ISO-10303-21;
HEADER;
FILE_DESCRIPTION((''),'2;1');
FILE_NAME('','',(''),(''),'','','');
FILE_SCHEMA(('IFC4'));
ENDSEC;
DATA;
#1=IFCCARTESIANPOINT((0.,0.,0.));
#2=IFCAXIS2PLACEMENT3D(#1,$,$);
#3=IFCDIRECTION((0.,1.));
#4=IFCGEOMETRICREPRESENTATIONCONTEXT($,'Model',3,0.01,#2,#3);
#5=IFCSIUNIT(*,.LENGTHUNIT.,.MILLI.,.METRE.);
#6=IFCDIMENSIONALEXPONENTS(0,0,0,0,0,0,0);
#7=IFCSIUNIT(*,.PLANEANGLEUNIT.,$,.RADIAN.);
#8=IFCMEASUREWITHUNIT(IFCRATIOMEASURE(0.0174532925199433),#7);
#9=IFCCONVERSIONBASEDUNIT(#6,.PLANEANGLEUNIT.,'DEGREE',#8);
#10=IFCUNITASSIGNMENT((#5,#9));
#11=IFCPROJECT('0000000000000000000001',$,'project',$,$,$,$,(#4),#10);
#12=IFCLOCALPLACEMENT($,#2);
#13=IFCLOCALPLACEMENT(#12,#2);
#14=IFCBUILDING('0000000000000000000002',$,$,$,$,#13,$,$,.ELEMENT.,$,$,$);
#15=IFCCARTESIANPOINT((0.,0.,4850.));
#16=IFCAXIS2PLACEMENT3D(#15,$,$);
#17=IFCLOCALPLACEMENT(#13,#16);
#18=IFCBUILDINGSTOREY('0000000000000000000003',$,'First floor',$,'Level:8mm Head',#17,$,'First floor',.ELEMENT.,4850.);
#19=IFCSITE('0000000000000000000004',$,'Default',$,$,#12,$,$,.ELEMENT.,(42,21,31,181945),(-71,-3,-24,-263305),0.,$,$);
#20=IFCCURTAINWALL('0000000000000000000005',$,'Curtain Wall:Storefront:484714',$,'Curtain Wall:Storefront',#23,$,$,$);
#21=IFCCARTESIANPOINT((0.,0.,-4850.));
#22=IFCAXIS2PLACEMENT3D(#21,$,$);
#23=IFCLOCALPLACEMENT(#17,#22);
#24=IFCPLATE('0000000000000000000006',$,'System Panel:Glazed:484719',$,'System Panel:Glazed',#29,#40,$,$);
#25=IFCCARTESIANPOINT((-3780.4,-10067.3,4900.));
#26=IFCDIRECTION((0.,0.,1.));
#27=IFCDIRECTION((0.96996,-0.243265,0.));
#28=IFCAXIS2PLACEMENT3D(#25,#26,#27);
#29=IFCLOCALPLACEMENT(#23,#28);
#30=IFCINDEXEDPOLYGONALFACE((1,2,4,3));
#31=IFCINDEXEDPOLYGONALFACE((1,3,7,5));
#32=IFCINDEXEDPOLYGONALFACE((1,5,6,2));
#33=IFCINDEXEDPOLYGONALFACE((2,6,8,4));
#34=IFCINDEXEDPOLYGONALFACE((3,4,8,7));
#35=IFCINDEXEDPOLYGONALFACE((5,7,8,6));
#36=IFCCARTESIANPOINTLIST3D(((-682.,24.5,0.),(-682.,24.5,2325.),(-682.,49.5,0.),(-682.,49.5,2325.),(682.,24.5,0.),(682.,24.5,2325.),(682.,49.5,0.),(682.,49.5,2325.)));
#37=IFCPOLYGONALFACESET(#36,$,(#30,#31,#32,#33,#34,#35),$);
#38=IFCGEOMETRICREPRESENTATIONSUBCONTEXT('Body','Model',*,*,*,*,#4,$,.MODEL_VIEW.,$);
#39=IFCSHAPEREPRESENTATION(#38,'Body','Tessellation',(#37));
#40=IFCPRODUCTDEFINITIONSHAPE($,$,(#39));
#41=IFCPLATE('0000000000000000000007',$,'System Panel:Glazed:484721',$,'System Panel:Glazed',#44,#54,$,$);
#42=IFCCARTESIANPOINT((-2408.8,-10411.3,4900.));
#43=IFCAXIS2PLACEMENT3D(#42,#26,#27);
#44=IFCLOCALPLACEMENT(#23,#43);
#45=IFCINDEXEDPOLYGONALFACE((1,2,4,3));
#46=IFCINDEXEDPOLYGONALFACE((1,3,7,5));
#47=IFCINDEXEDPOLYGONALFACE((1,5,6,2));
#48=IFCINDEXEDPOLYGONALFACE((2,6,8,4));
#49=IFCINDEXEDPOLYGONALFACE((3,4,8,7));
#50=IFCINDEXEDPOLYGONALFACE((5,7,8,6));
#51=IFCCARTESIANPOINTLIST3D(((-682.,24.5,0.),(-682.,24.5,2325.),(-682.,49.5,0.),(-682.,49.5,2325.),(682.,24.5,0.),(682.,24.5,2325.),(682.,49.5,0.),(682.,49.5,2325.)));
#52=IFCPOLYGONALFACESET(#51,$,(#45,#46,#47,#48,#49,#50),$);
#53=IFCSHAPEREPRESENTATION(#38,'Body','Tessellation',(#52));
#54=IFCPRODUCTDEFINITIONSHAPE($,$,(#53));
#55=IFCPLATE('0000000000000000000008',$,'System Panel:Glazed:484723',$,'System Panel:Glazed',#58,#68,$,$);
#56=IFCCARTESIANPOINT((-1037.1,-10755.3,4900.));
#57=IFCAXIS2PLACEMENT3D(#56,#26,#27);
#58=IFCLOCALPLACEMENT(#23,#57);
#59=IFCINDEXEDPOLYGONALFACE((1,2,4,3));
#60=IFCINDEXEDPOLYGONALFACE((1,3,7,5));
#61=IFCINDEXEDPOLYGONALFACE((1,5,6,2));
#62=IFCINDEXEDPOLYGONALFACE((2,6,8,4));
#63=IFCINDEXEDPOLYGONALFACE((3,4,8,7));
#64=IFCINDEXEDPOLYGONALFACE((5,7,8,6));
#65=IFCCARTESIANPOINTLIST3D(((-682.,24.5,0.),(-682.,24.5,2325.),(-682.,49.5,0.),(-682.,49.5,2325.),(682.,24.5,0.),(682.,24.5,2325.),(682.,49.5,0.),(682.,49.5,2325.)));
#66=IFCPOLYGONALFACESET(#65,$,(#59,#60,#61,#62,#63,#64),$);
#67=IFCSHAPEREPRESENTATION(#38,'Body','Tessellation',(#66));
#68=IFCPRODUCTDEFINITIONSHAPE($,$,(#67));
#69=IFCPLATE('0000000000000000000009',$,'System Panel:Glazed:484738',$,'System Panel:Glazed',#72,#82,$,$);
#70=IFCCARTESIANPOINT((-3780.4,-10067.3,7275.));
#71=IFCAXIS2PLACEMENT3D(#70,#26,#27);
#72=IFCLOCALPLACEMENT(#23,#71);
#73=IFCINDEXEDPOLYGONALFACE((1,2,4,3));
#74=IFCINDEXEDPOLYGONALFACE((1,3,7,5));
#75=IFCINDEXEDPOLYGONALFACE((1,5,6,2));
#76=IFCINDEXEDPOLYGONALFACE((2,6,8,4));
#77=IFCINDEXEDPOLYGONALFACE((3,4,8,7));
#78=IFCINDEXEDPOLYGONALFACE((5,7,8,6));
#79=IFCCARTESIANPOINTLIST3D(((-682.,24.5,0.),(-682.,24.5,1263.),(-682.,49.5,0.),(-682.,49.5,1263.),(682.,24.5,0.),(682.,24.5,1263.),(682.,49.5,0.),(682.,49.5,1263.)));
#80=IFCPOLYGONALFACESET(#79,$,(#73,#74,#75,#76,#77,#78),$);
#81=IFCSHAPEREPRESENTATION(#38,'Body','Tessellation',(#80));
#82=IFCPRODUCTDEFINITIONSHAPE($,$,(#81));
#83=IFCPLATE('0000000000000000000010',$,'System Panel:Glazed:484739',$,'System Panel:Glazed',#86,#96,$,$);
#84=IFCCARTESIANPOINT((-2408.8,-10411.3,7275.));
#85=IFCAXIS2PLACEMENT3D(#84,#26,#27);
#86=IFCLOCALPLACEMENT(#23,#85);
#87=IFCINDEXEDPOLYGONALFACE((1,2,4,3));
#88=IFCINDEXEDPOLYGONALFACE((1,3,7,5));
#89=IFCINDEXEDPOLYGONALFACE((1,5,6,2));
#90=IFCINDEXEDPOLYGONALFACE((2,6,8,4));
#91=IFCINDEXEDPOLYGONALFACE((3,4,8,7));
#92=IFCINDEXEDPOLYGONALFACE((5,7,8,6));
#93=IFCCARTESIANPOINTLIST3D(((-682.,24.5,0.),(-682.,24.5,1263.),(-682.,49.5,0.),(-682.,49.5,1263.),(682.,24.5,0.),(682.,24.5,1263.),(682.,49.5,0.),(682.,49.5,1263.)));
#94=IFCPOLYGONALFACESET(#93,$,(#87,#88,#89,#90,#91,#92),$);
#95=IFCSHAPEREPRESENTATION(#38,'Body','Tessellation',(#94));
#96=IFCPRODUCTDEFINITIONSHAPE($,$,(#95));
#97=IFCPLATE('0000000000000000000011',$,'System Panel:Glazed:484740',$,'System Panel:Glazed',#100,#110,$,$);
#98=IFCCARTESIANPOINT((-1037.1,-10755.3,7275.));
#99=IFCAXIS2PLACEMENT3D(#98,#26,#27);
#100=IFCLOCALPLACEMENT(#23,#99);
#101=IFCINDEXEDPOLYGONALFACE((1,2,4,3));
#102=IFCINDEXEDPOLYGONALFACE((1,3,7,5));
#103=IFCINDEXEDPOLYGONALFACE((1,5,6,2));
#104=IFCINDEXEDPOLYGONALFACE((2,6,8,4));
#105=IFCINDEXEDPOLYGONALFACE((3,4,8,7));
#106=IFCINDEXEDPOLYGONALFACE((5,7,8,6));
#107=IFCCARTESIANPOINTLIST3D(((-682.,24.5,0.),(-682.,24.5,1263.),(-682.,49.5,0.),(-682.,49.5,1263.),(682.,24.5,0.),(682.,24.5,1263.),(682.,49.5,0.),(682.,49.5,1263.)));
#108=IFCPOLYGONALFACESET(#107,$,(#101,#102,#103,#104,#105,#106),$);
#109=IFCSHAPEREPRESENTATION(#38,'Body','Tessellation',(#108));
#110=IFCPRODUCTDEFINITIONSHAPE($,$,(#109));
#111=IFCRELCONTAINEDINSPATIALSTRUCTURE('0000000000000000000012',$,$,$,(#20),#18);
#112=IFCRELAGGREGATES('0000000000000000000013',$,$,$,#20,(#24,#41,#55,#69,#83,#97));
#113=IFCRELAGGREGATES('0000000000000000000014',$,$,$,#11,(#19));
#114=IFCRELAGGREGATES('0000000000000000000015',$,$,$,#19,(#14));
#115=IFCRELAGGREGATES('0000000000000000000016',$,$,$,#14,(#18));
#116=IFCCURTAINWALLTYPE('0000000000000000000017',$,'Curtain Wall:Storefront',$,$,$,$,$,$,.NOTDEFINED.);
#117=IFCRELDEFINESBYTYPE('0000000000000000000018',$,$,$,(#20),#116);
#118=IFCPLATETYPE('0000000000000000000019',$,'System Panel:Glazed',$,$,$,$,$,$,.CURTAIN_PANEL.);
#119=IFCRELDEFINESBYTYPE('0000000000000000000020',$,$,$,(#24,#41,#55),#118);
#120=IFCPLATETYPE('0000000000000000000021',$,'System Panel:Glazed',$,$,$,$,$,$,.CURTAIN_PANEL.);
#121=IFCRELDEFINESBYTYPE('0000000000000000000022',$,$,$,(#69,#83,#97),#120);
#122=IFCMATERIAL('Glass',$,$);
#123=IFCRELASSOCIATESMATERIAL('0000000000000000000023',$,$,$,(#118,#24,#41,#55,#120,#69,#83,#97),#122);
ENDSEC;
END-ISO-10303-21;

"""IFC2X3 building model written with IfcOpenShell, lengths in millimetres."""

from ifc_helpers import new_model, entity, si_unit, converted_unit, direction, frame, origin, origin_2d_with_axis, place, context, subcontext, project, spatial, rectangle, extrude, source, transform, mapped, material, type_object, type_shapes, element, aggregate, save


model = new_model("IFC2X3")

# Units and contexts
model_context = context("Model", 3, precision=0.01, world=origin(), true_north=direction((0.0, 1.0)))
body_context = subcontext(model_context, "Body", "Model", "MODEL_VIEW")
ifc_project = project(units=[si_unit("LENGTHUNIT", "METRE", prefix="MILLI"), converted_unit("PLANEANGLEUNIT", "DEGREE", entity("IfcRatioMeasure", 0.0174532925199433), si_unit("PLANEANGLEUNIT", "RADIAN"), dimensions=[0, 0, 0, 0, 0, 0, 0])], contexts=[model_context])

# Site, building, storey
site_placement = place(None, origin())
site = spatial("IfcSite", under=ifc_project, at=site_placement, Name="Default", CompositionType="ELEMENT", RefLatitude=(42, 21, 31, 181945), RefLongitude=(-71, -3, -24, -263305), RefElevation=0.0)
building_placement = place(site_placement, origin())
building = spatial("IfcBuilding", under=site, at=building_placement, CompositionType="ELEMENT")
storey_placement = place(building_placement, frame((0.0, 0.0, 4850.0)))
storey = spatial("IfcBuildingStorey", under=building, at=storey_placement, Name="First floor", ObjectType="Level:8mm Head", LongName="First floor", CompositionType="ELEMENT", Elevation=4850.0)

# Curtain wall, plates
curtain_wall_type = type_object("IfcCurtainWallType", Name="Curtain Wall:Storefront", PredefinedType="NOTDEFINED")
curtain_wall_placement = place(storey_placement, frame((0.0, 0.0, -4850.0)))
curtain_wall = element("IfcCurtainWall", 1, at=curtain_wall_placement, inside=storey, type_object=curtain_wall_type, Name="Curtain Wall:Storefront:484714", ObjectType="Curtain Wall:Storefront")
ifc_material_1 = material(Name="Glass")
plate_type_1 = type_object("IfcPlateType", Name="System Panel:Glazed", PredefinedType="CURTAIN_PANEL", material=ifc_material_1)
shared_shape_1 = source(origin(), body_context, "Body", "SweptSolid", [
    extrude(rectangle(XDim=25.0, YDim=1364.1, at=origin_2d_with_axis()), frame((0.0, 37.0, 0.0), z_axis=(0.0, 0.0, 1.0), x_axis=(0.0, 1.0, 0.0)), (0.0, 0.0, 1.0), 2325.0),
])
type_shapes(plate_type_1, [shared_shape_1])
plate_1_placement = place(curtain_wall_placement, frame((-3780.4, -10067.3, 4900.0), z_axis=(0.0, 0.0, 1.0), x_axis=(0.96996, -0.243265, 0.0)))
plate_1 = element("IfcPlate", 2, at=plate_1_placement, type_object=plate_type_1, material=ifc_material_1, Name="System Panel:Glazed:484719", ObjectType="System Panel:Glazed", context=body_context, shape_type="MappedRepresentation", body=[
    mapped(shared_shape_1, transform((0.0, 0.0, 0.0), scale=1.0)),
])
plate_2_placement = place(curtain_wall_placement, frame((-2408.8, -10411.3, 4900.0), z_axis=(0.0, 0.0, 1.0), x_axis=(0.96996, -0.243265, 0.0)))
plate_2 = element("IfcPlate", 3, at=plate_2_placement, type_object=plate_type_1, material=ifc_material_1, Name="System Panel:Glazed:484721", ObjectType="System Panel:Glazed", context=body_context, shape_type="MappedRepresentation", body=[
    mapped(shared_shape_1, transform((0.0, 0.0, 0.0), scale=1.0)),
])
plate_3_placement = place(curtain_wall_placement, frame((-1037.1, -10755.3, 4900.0), z_axis=(0.0, 0.0, 1.0), x_axis=(0.96996, -0.243265, 0.0)))
plate_3 = element("IfcPlate", 4, at=plate_3_placement, type_object=plate_type_1, material=ifc_material_1, Name="System Panel:Glazed:484723", ObjectType="System Panel:Glazed", context=body_context, shape_type="MappedRepresentation", body=[
    mapped(shared_shape_1, transform((0.0, 0.0, 0.0), scale=1.0)),
])
plate_type_2 = type_object("IfcPlateType", Name="System Panel:Glazed", PredefinedType="CURTAIN_PANEL", material=ifc_material_1)
shared_shape_2 = source(origin(), body_context, "Body", "SweptSolid", [
    extrude(rectangle(XDim=25.0, YDim=1364.1, at=origin_2d_with_axis()), frame((0.0, 37.0, 0.0), z_axis=(0.0, 0.0, 1.0), x_axis=(0.0, 1.0, 0.0)), (0.0, 0.0, 1.0), 1263.0),
])
type_shapes(plate_type_2, [shared_shape_2])
plate_4_placement = place(curtain_wall_placement, frame((-3780.4, -10067.3, 7275.0), z_axis=(0.0, 0.0, 1.0), x_axis=(0.96996, -0.243265, 0.0)))
plate_4 = element("IfcPlate", 5, at=plate_4_placement, type_object=plate_type_2, material=ifc_material_1, Name="System Panel:Glazed:484738", ObjectType="System Panel:Glazed", context=body_context, shape_type="MappedRepresentation", body=[
    mapped(shared_shape_2, transform((0.0, 0.0, 0.0), scale=1.0)),
])
plate_5_placement = place(curtain_wall_placement, frame((-2408.8, -10411.3, 7275.0), z_axis=(0.0, 0.0, 1.0), x_axis=(0.96996, -0.243265, 0.0)))
plate_5 = element("IfcPlate", 6, at=plate_5_placement, type_object=plate_type_2, material=ifc_material_1, Name="System Panel:Glazed:484739", ObjectType="System Panel:Glazed", context=body_context, shape_type="MappedRepresentation", body=[
    mapped(shared_shape_2, transform((0.0, 0.0, 0.0), scale=1.0)),
])
plate_6_placement = place(curtain_wall_placement, frame((-1037.1, -10755.3, 7275.0), z_axis=(0.0, 0.0, 1.0), x_axis=(0.96996, -0.243265, 0.0)))
plate_6 = element("IfcPlate", 7, at=plate_6_placement, type_object=plate_type_2, material=ifc_material_1, Name="System Panel:Glazed:484740", ObjectType="System Panel:Glazed", context=body_context, shape_type="MappedRepresentation", body=[
    mapped(shared_shape_2, transform((0.0, 0.0, 0.0), scale=1.0)),
])
aggregate(curtain_wall, [plate_1, plate_2, plate_3, plate_4, plate_5, plate_6])

save(model, "model.ifc")
